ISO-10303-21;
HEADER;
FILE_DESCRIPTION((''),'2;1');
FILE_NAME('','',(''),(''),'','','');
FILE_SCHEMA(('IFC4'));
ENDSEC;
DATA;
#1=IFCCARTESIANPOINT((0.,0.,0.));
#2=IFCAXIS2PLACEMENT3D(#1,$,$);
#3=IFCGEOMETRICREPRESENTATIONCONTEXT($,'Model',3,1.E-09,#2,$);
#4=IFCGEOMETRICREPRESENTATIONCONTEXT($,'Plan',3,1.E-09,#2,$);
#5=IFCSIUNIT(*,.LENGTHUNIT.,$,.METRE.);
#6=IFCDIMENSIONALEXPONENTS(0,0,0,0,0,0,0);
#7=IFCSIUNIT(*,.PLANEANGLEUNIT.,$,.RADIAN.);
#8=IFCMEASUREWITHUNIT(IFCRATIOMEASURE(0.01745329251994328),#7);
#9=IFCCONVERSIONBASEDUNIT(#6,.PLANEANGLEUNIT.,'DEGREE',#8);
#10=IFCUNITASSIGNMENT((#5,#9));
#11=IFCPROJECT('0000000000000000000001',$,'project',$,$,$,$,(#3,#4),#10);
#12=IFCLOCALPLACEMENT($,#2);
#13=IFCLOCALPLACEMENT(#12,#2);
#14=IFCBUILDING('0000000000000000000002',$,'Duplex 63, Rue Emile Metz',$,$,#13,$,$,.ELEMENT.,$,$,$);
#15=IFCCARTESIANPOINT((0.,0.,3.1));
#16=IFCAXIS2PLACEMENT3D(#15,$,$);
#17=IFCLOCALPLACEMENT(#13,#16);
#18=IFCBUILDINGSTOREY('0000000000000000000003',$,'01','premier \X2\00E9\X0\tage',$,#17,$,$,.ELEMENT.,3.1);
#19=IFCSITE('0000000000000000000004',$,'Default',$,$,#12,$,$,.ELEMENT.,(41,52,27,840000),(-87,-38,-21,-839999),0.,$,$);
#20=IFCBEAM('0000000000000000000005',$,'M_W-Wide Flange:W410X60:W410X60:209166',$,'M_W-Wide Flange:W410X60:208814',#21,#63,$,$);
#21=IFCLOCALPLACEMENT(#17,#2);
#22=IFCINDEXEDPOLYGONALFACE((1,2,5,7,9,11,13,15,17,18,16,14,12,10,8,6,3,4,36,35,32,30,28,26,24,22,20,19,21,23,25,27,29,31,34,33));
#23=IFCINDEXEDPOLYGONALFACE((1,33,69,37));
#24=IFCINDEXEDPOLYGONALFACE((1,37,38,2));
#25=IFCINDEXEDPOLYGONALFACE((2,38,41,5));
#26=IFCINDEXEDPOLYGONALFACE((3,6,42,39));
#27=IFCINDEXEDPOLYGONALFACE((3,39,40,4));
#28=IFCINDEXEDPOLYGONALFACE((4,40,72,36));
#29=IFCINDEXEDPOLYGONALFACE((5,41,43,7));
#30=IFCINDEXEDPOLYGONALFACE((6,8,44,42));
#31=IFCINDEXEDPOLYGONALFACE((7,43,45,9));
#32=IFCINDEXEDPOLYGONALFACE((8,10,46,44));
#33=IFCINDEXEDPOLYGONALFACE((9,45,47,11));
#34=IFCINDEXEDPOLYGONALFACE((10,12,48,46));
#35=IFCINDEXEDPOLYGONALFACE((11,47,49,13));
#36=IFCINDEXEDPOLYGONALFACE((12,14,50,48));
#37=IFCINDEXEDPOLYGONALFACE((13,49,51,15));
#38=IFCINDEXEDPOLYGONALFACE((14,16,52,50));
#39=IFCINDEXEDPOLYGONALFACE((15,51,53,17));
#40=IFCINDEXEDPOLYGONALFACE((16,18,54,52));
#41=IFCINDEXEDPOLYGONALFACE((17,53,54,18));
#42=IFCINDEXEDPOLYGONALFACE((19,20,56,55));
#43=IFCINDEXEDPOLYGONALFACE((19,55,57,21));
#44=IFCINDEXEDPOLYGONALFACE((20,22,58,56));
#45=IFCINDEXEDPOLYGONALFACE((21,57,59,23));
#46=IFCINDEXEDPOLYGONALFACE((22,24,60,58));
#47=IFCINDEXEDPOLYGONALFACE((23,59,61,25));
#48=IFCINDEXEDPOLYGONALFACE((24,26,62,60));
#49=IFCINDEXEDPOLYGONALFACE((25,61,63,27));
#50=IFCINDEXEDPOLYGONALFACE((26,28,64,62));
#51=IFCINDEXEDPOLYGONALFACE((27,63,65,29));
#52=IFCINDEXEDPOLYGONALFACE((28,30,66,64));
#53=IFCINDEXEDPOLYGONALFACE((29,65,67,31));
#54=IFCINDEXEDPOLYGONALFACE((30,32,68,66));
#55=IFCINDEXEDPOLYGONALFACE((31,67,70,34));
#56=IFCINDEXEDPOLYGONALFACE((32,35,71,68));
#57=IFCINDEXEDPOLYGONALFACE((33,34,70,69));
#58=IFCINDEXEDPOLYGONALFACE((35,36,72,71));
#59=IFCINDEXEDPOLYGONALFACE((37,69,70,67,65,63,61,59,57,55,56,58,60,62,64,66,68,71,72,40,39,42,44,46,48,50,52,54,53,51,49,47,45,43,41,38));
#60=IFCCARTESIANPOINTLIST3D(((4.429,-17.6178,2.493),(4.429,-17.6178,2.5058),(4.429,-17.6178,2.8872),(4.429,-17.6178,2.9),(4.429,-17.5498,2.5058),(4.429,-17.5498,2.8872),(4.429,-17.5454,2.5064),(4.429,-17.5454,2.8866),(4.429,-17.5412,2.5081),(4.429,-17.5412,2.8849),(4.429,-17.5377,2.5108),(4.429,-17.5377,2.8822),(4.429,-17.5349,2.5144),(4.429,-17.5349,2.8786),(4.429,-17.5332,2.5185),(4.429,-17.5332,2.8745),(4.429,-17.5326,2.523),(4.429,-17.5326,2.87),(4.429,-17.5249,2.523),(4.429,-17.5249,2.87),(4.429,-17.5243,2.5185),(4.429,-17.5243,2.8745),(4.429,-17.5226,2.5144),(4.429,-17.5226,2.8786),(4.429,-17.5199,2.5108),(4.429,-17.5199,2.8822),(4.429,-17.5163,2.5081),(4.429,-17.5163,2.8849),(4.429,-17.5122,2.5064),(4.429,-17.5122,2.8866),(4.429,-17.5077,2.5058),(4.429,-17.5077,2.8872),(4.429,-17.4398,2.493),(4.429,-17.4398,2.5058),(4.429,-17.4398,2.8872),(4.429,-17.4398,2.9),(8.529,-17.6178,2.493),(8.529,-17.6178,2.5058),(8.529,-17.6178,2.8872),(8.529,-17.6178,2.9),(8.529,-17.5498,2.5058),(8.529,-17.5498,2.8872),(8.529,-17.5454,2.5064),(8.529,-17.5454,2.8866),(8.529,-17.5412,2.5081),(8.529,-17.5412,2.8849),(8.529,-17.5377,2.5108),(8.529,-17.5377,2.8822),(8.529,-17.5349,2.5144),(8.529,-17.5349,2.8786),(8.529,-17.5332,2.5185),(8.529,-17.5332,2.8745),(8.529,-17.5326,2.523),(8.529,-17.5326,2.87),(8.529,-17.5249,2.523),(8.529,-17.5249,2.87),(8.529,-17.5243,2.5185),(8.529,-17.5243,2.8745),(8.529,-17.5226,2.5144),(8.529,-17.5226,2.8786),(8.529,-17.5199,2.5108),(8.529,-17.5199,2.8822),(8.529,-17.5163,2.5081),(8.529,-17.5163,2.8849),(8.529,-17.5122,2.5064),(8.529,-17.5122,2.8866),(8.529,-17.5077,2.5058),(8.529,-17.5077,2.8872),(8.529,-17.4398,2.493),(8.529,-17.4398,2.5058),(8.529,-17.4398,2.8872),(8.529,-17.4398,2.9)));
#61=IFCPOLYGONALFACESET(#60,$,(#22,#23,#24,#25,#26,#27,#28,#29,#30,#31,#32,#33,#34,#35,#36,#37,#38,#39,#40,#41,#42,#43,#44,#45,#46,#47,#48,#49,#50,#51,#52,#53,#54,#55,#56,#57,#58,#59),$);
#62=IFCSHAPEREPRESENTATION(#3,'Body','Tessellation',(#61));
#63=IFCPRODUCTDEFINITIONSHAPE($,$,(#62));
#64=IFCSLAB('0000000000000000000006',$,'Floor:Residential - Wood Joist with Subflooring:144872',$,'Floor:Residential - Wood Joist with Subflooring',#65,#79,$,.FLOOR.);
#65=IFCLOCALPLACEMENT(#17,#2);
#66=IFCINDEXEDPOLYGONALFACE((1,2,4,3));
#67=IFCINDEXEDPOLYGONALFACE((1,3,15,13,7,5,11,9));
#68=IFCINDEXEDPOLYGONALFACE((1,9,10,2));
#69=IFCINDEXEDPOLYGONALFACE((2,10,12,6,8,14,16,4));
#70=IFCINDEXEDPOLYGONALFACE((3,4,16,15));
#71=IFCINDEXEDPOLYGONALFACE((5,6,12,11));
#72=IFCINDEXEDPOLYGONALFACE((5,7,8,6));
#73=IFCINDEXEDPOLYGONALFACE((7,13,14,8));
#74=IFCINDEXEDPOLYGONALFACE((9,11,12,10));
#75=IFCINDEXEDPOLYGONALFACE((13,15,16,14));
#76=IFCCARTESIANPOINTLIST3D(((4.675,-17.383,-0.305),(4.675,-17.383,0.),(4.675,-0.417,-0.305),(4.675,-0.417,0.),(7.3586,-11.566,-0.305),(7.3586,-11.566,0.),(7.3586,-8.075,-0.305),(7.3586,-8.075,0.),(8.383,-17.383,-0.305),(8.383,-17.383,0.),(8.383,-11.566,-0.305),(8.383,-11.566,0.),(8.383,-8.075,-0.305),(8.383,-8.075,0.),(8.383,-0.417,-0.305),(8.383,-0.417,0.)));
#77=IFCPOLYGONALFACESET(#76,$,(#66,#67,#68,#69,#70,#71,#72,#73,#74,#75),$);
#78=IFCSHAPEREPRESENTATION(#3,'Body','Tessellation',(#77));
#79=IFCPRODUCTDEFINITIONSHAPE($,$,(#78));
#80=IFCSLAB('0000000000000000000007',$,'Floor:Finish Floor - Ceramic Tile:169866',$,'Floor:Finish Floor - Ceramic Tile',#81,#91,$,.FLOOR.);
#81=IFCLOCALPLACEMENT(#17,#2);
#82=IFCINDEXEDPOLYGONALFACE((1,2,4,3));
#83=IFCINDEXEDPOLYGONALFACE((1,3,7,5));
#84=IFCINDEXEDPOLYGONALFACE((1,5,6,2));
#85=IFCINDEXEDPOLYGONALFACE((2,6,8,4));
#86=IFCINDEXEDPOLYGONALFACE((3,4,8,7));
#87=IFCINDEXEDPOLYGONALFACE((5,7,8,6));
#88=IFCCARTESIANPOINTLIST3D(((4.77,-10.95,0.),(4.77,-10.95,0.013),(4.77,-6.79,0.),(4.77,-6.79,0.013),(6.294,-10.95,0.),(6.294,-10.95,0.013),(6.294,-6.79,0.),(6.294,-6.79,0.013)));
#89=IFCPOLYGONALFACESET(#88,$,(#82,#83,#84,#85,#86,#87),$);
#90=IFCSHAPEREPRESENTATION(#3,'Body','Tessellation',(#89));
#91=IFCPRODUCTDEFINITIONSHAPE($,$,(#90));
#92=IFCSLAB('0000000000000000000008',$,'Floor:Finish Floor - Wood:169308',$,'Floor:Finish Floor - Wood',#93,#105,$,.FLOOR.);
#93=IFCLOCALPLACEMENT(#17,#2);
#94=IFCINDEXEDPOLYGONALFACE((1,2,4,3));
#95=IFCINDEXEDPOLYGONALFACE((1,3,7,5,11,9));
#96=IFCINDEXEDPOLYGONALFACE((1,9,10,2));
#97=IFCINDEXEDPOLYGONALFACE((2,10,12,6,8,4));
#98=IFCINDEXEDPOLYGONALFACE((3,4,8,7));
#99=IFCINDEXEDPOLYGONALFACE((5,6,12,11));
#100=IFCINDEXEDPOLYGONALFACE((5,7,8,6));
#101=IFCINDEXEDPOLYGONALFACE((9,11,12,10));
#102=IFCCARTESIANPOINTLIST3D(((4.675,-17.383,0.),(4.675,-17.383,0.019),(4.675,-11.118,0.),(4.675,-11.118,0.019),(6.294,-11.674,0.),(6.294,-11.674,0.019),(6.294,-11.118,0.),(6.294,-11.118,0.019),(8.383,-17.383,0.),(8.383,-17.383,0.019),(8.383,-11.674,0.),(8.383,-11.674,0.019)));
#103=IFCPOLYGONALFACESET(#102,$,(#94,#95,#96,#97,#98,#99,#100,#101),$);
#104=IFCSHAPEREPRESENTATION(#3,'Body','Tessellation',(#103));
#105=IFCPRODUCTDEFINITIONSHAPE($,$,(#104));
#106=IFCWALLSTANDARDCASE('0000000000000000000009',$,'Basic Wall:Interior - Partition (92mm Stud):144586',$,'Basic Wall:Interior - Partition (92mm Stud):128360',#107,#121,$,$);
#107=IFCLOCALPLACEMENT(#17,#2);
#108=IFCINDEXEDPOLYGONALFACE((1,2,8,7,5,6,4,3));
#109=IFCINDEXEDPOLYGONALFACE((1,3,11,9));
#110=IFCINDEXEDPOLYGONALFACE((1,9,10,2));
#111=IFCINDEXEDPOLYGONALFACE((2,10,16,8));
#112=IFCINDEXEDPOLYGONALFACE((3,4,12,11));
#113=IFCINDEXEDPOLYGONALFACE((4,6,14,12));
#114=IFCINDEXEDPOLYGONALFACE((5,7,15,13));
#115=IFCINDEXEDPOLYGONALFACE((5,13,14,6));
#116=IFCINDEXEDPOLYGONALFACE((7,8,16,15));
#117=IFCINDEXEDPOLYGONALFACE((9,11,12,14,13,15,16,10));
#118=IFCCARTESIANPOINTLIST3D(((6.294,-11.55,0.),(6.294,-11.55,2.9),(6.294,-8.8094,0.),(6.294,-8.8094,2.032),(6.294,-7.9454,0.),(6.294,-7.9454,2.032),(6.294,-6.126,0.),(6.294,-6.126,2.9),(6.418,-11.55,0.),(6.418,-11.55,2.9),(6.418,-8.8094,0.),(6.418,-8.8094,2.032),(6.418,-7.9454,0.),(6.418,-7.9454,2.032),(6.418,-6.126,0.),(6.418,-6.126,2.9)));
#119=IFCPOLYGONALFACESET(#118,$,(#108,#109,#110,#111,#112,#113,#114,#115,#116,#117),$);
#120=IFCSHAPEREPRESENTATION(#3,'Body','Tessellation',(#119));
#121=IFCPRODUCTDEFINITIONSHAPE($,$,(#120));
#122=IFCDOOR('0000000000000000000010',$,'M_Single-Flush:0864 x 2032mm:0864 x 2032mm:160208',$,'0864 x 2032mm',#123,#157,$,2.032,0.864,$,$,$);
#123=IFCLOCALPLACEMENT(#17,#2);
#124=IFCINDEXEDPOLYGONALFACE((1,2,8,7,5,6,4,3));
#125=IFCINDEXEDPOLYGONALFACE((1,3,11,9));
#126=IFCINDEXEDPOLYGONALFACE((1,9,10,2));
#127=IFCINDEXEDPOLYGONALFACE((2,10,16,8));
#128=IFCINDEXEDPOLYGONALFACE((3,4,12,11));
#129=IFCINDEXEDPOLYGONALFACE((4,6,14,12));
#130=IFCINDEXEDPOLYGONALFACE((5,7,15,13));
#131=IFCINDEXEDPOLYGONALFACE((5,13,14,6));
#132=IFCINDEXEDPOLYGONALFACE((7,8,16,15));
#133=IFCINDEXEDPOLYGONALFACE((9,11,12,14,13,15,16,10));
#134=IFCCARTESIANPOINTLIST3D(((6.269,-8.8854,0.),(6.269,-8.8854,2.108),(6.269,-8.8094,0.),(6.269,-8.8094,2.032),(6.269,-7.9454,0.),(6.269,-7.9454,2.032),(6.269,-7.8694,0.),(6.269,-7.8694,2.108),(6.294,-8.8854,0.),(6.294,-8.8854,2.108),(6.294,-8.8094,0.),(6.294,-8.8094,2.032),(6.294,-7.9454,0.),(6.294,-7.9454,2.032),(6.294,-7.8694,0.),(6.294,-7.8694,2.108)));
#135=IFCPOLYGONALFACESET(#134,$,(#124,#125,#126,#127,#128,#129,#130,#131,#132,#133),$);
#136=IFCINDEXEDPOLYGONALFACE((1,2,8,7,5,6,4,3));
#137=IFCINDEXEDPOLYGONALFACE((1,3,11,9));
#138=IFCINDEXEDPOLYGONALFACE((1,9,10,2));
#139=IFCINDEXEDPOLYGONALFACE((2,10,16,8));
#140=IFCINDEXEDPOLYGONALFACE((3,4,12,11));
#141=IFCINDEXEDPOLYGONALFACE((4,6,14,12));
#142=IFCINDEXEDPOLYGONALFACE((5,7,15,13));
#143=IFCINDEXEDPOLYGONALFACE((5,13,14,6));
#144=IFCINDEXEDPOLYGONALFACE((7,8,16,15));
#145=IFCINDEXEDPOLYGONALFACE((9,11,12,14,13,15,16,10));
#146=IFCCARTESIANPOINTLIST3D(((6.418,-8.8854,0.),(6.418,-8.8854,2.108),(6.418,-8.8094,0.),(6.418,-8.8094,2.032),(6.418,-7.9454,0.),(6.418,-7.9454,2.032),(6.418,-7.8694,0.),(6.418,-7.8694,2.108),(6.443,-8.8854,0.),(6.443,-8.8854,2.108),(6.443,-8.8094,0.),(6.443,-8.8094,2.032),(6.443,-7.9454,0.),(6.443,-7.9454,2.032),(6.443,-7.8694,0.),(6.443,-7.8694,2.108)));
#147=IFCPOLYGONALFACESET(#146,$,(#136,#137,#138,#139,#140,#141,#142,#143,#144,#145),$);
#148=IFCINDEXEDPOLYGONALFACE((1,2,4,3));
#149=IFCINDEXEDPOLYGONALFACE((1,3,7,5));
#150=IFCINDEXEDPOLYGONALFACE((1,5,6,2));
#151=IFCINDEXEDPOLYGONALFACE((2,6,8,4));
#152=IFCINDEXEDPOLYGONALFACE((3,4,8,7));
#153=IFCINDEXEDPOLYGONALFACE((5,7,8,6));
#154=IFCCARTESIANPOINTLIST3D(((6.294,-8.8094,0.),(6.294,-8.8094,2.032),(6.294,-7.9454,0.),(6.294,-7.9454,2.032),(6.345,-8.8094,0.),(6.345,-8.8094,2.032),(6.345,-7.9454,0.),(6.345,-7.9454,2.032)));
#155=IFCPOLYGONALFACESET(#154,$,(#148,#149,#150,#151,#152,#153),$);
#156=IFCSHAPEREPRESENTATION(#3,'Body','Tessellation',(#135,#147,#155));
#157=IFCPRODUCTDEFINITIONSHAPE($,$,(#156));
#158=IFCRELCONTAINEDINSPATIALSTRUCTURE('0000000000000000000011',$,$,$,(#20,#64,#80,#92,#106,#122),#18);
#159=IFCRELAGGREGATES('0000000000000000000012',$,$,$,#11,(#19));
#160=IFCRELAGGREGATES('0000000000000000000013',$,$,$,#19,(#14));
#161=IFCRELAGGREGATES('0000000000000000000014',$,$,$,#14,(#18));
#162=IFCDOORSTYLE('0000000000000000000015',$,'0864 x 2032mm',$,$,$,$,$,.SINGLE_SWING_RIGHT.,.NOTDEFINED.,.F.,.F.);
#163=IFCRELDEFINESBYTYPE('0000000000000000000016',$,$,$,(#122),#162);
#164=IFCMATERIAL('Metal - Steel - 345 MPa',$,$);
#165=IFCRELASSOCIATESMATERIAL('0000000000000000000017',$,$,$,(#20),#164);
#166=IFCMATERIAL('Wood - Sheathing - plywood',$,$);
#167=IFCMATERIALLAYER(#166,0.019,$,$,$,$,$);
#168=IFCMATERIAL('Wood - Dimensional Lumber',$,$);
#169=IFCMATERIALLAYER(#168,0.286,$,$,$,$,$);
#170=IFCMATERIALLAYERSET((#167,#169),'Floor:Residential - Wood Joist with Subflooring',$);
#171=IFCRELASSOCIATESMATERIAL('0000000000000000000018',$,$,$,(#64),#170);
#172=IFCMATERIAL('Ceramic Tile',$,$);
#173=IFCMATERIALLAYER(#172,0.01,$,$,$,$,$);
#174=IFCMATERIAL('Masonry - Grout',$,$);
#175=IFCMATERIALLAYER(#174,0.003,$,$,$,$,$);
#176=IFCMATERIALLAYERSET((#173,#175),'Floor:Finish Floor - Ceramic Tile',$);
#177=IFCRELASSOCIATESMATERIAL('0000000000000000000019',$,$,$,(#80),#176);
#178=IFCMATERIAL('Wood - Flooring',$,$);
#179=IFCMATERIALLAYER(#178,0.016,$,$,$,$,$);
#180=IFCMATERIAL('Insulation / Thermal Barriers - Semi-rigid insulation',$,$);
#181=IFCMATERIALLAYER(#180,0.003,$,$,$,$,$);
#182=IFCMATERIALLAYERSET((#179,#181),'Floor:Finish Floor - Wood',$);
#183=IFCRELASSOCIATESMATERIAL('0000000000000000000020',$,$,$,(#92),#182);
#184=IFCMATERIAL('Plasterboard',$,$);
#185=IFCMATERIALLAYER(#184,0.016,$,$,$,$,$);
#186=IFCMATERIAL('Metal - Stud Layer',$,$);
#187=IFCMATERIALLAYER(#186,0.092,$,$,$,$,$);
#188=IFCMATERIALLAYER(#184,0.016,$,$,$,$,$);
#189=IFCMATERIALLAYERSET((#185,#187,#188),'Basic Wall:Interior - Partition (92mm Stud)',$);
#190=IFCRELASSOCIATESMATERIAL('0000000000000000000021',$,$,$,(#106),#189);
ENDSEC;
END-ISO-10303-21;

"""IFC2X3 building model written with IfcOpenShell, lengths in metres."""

from ifc_helpers import new_model, entity, si_unit, converted_unit, frame, frame_2d, origin, origin_2d_with_axis, place, context, project, spatial, polyline, circle_curve, parameter, trimmed, segment, composite_curve, rectangle, outline, extrude, source, transform, mapped, material, layer, layer_set, layer_usage, type_object, type_shapes, element, fill, save


model = new_model("IFC2X3")

# Units and contexts
model_context = context("Model", 3, precision=1e-09, world=origin())
plan_context = context("Plan", 3, precision=1e-09, world=origin())
ifc_project = project(units=[si_unit("LENGTHUNIT", "METRE"), converted_unit("PLANEANGLEUNIT", "DEGREE", entity("IfcRatioMeasure", 0.01745329251994328), si_unit("PLANEANGLEUNIT", "RADIAN"), dimensions=[0, 0, 0, 0, 0, 0, 0])], contexts=[model_context, plan_context])

# Site, building, storey
site_placement = place(None, origin())
site = spatial("IfcSite", under=ifc_project, at=site_placement, Name="Default", CompositionType="ELEMENT", RefLatitude=(41, 52, 27, 840000), RefLongitude=(-87, -38, -21, -839999), RefElevation=0.0)
building_placement = place(site_placement, origin())
building = spatial("IfcBuilding", under=site, at=building_placement, Name="Duplex 63, Rue Emile Metz", CompositionType="ELEMENT")
storey_placement = place(building_placement, frame((0.0, 0.0, 3.1)))
storey = spatial("IfcBuildingStorey", under=building, at=storey_placement, Name="01", Description="premier étage", CompositionType="ELEMENT", Elevation=3.1)

# Beam
ifc_material_1 = material(Name="Metal - Steel - 345 MPa")
beam_placement = place(storey_placement, frame((4.429, -17.5288, 2.9), z_axis=(0.0, 0.0, 1.0), x_axis=(0.0, -1.0, 0.0)))
element("IfcBeam", 1, at=beam_placement, inside=storey, material=ifc_material_1, Name="M_W-Wide Flange:W410X60:W410X60:209166", ObjectType="M_W-Wide Flange:W410X60:208814", context=model_context, shape_type="SweptSolid", body=[
    extrude(outline(composite_curve([segment(polyline([(-0.089, -0.1907), (-0.089, -0.2035)]), True, "CONTINUOUS"), segment(polyline([(-0.089, -0.2035), (0.089, -0.2035)]), True, "CONTINUOUS"), segment(polyline([(0.089, -0.2035), (0.089, -0.1907)]), True, "CONTINUOUS"), segment(polyline([(0.089, -0.1907), (0.021, -0.1907)]), True, "CONTINUOUS"), segment(trimmed(circle_curve(frame_2d((0.021, -0.1735), x_axis=(0.0, -1.0)), 0.0172), [parameter(270.0)], [parameter(360.0)], True, "PARAMETER"), False, "CONTINUOUS"), segment(polyline([(0.0038, -0.1735), (0.0038, 0.1735)]), True, "CONTINUOUS"), segment(trimmed(circle_curve(frame_2d((0.021, 0.1735), x_axis=(-1.0, 0.0)), 0.0172), [parameter(270.0)], [parameter(360.0)], True, "PARAMETER"), False, "CONTINUOUS"), segment(polyline([(0.021, 0.1907), (0.089, 0.1907)]), True, "CONTINUOUS"), segment(polyline([(0.089, 0.1907), (0.089, 0.2035)]), True, "CONTINUOUS"), segment(polyline([(0.089, 0.2035), (-0.089, 0.2035)]), True, "CONTINUOUS"), segment(polyline([(-0.089, 0.2035), (-0.089, 0.1907)]), True, "CONTINUOUS"), segment(polyline([(-0.089, 0.1907), (-0.0211, 0.1907)]), True, "CONTINUOUS"), segment(trimmed(circle_curve(frame_2d((-0.0211, 0.1735), x_axis=(0.0, 1.0)), 0.0172), [parameter(270.0)], [parameter(0.0)], True, "PARAMETER"), False, "CONTINUOUS"), segment(polyline([(-0.0039, 0.1735), (-0.0039, -0.1735)]), True, "CONTINUOUS"), segment(trimmed(circle_curve(frame_2d((-0.0211, -0.1735), x_axis=(1.0, 0.0)), 0.0172), [parameter(270.0)], [parameter(0.0)], True, "PARAMETER"), False, "CONTINUOUS"), segment(polyline([(-0.0211, -0.1907), (-0.089, -0.1907)]), True, "CONTINUOUS")], self_intersect=False)), frame((0.0, 0.0, -0.2035), z_axis=(0.0, -1.0, 0.0), x_axis=(1.0, 0.0, 0.0)), (0.0, 0.0, -1.0), 4.1),
])

# Slabs
ifc_material_2 = material(Name="Wood - Sheathing - plywood")
ifc_layer_1 = layer(ifc_material_2, 0.019)
ifc_material_3 = material(Name="Wood - Dimensional Lumber")
ifc_layer_2 = layer(ifc_material_3, 0.286)
ifc_layer_set_1 = layer_set([ifc_layer_1, ifc_layer_2], Name="Floor:Residential - Wood Joist with Subflooring")
ifc_layer_usage_1 = layer_usage(ifc_layer_set_1, "AXIS3", "POSITIVE", 0.0)
slab_1_placement = place(storey_placement, frame((4.675, -17.383, -0.305)))
element("IfcSlab", 2, at=slab_1_placement, inside=storey, material=ifc_layer_usage_1, Name="Floor:Residential - Wood Joist with Subflooring:144872", ObjectType="Floor:Residential - Wood Joist with Subflooring", PredefinedType="FLOOR", context=model_context, shape_type="SweptSolid", body=[
    extrude(outline(polyline([(-1.854, 8.483), (-1.854, 0.825), (-0.8296, 0.825), (-0.8296, -2.666), (-1.854, -2.666), (-1.854, -8.483), (1.854, -8.483), (1.854, 8.483), (-1.854, 8.483)])), frame((1.854, 8.483, 0.305), z_axis=(0.0, 0.0, -1.0), x_axis=(-1.0, 0.0, 0.0)), (0.0, 0.0, 1.0), 0.305),
])
ifc_material_4 = material(Name="Ceramic Tile")
ifc_layer_3 = layer(ifc_material_4, 0.01)
ifc_material_5 = material(Name="Masonry - Grout")
ifc_layer_4 = layer(ifc_material_5, 0.003)
ifc_layer_set_2 = layer_set([ifc_layer_3, ifc_layer_4], Name="Floor:Finish Floor - Ceramic Tile")
ifc_layer_usage_2 = layer_usage(ifc_layer_set_2, "AXIS3", "POSITIVE", 0.0)
slab_2_placement = place(storey_placement, frame((4.77, -10.95, 0.0)))
element("IfcSlab", 3, at=slab_2_placement, inside=storey, material=ifc_layer_usage_2, Name="Floor:Finish Floor - Ceramic Tile:169866", ObjectType="Floor:Finish Floor - Ceramic Tile", PredefinedType="FLOOR", context=model_context, shape_type="SweptSolid", body=[
    extrude(rectangle(XDim=4.16, YDim=1.524, at=frame_2d((0.0, 0.0), x_axis=(0.0, -1.0))), frame((0.762, 2.08, 0.013), z_axis=(0.0, 0.0, -1.0), x_axis=(-1.0, 0.0, 0.0)), (0.0, 0.0, 1.0), 0.013),
])
ifc_material_6 = material(Name="Wood - Flooring")
ifc_layer_5 = layer(ifc_material_6, 0.016)
ifc_material_7 = material(Name="Insulation / Thermal Barriers - Semi-rigid insulation")
ifc_layer_6 = layer(ifc_material_7, 0.003)
ifc_layer_set_3 = layer_set([ifc_layer_5, ifc_layer_6], Name="Floor:Finish Floor - Wood")
ifc_layer_usage_3 = layer_usage(ifc_layer_set_3, "AXIS3", "POSITIVE", 0.0)
slab_3_placement = place(storey_placement, frame((4.675, -17.383, 0.0)))
element("IfcSlab", 4, at=slab_3_placement, inside=storey, material=ifc_layer_usage_3, Name="Floor:Finish Floor - Wood:169308", ObjectType="Floor:Finish Floor - Wood", PredefinedType="FLOOR", context=model_context, shape_type="SweptSolid", body=[
    extrude(outline(polyline([(-1.854, 2.5765), (-1.854, -3.1325), (1.854, -3.1325), (1.854, 3.1325), (0.235, 3.1325), (0.235, 2.5765), (-1.854, 2.5765)])), frame((1.854, 3.1325, 0.019), z_axis=(0.0, 0.0, -1.0), x_axis=(-1.0, 0.0, 0.0)), (0.0, 0.0, 1.0), 0.019),
])

# Wall, opening, door
ifc_material_8 = material(Name="Plasterboard")
ifc_layer_7 = layer(ifc_material_8, 0.016)
ifc_material_9 = material(Name="Metal - Stud Layer")
ifc_layer_8 = layer(ifc_material_9, 0.092)
ifc_layer_9 = layer(ifc_material_8, 0.016)
ifc_layer_set_4 = layer_set([ifc_layer_7, ifc_layer_8, ifc_layer_9], Name="Basic Wall:Interior - Partition (92mm Stud)")
ifc_layer_usage_4 = layer_usage(ifc_layer_set_4, "AXIS2", "NEGATIVE", 0.062)
wall_1_placement = place(storey_placement, frame((6.356, -11.55, 0.0), z_axis=(0.0, 0.0, 1.0), x_axis=(0.0, 1.0, 0.0)))
wall_1 = element("IfcWallStandardCase", 5, at=wall_1_placement, inside=storey, material=ifc_layer_usage_4, Name="Basic Wall:Interior - Partition (92mm Stud):144586", ObjectType="Basic Wall:Interior - Partition (92mm Stud):128360", context=model_context, shape_type="SweptSolid", body=[
    extrude(rectangle(XDim=5.424, YDim=0.124, at=frame_2d((2.712, 0.0), x_axis=(-1.0, 0.0))), origin(), (0.0, 0.0, 1.0), 2.9),
])
opening_1_placement = place(wall_1_placement, frame((2.7406, -0.062, 0.0)))
opening_1 = element("IfcOpeningElement", 6, at=opening_1_placement, cuts=wall_1, ObjectType="Opening", context=model_context, shape_type="SweptSolid", body=[
    extrude(rectangle(XDim=0.864, YDim=2.032, at=frame_2d((1.016, 0.432), x_axis=(0.0, 1.0))), frame((0.0, 0.0, 0.0), z_axis=(0.0, 1.0, 0.0), x_axis=(0.0, 0.0, 1.0)), (0.0, 0.0, 1.0), 0.124),
])
door_style = type_object("IfcDoorStyle", Name="0864 x 2032mm", ConstructionType="NOTDEFINED", OperationType="SINGLE_SWING_RIGHT", ParameterTakesPrecedence=False, Sizeable=False)
shared_shape_1 = source(origin(), model_context, "Body", "SweptSolid", [
    extrude(outline(polyline([(-0.508, -1.073), (0.508, -1.073), (0.508, 1.035), (0.432, 1.035), (0.432, -0.997), (-0.432, -0.997), (-0.432, 1.035), (-0.508, 1.035), (-0.508, -1.073)])), frame((0.432, 0.124, 1.035), z_axis=(0.0, 1.0, 0.0), x_axis=(1.0, 0.0, 0.0)), (0.0, 0.0, 1.0), 0.025),
    extrude(outline(polyline([(-1.073, -0.508), (1.035, -0.508), (1.035, -0.432), (-0.997, -0.432), (-0.997, 0.432), (1.035, 0.432), (1.035, 0.508), (-1.073, 0.508), (-1.073, -0.508)])), frame((0.432, -0.025, 1.035), z_axis=(0.0, 1.0, 0.0), x_axis=(0.0, 0.0, -1.0)), (0.0, 0.0, 1.0), 0.025),
    extrude(rectangle(XDim=0.051, YDim=0.864, at=origin_2d_with_axis()), frame((0.432, 0.0985, 0.0), z_axis=(0.0, 0.0, 1.0), x_axis=(0.0, 1.0, 0.0)), (0.0, 0.0, 1.0), 2.032),
])
type_shapes(door_style, [shared_shape_1])
door_placement = place(opening_1_placement, origin())
door = element("IfcDoor", 7, at=door_placement, inside=storey, type_object=door_style, Name="M_Single-Flush:0864 x 2032mm:0864 x 2032mm:160208", ObjectType="0864 x 2032mm", OverallHeight=2.032, OverallWidth=0.864, context=model_context, shape_type="MappedRepresentation", body=[
    mapped(shared_shape_1, transform((0.0, 0.0, 0.0), scale=1.0)),
])
fill(opening_1, door)

save(model, "model.ifc")
